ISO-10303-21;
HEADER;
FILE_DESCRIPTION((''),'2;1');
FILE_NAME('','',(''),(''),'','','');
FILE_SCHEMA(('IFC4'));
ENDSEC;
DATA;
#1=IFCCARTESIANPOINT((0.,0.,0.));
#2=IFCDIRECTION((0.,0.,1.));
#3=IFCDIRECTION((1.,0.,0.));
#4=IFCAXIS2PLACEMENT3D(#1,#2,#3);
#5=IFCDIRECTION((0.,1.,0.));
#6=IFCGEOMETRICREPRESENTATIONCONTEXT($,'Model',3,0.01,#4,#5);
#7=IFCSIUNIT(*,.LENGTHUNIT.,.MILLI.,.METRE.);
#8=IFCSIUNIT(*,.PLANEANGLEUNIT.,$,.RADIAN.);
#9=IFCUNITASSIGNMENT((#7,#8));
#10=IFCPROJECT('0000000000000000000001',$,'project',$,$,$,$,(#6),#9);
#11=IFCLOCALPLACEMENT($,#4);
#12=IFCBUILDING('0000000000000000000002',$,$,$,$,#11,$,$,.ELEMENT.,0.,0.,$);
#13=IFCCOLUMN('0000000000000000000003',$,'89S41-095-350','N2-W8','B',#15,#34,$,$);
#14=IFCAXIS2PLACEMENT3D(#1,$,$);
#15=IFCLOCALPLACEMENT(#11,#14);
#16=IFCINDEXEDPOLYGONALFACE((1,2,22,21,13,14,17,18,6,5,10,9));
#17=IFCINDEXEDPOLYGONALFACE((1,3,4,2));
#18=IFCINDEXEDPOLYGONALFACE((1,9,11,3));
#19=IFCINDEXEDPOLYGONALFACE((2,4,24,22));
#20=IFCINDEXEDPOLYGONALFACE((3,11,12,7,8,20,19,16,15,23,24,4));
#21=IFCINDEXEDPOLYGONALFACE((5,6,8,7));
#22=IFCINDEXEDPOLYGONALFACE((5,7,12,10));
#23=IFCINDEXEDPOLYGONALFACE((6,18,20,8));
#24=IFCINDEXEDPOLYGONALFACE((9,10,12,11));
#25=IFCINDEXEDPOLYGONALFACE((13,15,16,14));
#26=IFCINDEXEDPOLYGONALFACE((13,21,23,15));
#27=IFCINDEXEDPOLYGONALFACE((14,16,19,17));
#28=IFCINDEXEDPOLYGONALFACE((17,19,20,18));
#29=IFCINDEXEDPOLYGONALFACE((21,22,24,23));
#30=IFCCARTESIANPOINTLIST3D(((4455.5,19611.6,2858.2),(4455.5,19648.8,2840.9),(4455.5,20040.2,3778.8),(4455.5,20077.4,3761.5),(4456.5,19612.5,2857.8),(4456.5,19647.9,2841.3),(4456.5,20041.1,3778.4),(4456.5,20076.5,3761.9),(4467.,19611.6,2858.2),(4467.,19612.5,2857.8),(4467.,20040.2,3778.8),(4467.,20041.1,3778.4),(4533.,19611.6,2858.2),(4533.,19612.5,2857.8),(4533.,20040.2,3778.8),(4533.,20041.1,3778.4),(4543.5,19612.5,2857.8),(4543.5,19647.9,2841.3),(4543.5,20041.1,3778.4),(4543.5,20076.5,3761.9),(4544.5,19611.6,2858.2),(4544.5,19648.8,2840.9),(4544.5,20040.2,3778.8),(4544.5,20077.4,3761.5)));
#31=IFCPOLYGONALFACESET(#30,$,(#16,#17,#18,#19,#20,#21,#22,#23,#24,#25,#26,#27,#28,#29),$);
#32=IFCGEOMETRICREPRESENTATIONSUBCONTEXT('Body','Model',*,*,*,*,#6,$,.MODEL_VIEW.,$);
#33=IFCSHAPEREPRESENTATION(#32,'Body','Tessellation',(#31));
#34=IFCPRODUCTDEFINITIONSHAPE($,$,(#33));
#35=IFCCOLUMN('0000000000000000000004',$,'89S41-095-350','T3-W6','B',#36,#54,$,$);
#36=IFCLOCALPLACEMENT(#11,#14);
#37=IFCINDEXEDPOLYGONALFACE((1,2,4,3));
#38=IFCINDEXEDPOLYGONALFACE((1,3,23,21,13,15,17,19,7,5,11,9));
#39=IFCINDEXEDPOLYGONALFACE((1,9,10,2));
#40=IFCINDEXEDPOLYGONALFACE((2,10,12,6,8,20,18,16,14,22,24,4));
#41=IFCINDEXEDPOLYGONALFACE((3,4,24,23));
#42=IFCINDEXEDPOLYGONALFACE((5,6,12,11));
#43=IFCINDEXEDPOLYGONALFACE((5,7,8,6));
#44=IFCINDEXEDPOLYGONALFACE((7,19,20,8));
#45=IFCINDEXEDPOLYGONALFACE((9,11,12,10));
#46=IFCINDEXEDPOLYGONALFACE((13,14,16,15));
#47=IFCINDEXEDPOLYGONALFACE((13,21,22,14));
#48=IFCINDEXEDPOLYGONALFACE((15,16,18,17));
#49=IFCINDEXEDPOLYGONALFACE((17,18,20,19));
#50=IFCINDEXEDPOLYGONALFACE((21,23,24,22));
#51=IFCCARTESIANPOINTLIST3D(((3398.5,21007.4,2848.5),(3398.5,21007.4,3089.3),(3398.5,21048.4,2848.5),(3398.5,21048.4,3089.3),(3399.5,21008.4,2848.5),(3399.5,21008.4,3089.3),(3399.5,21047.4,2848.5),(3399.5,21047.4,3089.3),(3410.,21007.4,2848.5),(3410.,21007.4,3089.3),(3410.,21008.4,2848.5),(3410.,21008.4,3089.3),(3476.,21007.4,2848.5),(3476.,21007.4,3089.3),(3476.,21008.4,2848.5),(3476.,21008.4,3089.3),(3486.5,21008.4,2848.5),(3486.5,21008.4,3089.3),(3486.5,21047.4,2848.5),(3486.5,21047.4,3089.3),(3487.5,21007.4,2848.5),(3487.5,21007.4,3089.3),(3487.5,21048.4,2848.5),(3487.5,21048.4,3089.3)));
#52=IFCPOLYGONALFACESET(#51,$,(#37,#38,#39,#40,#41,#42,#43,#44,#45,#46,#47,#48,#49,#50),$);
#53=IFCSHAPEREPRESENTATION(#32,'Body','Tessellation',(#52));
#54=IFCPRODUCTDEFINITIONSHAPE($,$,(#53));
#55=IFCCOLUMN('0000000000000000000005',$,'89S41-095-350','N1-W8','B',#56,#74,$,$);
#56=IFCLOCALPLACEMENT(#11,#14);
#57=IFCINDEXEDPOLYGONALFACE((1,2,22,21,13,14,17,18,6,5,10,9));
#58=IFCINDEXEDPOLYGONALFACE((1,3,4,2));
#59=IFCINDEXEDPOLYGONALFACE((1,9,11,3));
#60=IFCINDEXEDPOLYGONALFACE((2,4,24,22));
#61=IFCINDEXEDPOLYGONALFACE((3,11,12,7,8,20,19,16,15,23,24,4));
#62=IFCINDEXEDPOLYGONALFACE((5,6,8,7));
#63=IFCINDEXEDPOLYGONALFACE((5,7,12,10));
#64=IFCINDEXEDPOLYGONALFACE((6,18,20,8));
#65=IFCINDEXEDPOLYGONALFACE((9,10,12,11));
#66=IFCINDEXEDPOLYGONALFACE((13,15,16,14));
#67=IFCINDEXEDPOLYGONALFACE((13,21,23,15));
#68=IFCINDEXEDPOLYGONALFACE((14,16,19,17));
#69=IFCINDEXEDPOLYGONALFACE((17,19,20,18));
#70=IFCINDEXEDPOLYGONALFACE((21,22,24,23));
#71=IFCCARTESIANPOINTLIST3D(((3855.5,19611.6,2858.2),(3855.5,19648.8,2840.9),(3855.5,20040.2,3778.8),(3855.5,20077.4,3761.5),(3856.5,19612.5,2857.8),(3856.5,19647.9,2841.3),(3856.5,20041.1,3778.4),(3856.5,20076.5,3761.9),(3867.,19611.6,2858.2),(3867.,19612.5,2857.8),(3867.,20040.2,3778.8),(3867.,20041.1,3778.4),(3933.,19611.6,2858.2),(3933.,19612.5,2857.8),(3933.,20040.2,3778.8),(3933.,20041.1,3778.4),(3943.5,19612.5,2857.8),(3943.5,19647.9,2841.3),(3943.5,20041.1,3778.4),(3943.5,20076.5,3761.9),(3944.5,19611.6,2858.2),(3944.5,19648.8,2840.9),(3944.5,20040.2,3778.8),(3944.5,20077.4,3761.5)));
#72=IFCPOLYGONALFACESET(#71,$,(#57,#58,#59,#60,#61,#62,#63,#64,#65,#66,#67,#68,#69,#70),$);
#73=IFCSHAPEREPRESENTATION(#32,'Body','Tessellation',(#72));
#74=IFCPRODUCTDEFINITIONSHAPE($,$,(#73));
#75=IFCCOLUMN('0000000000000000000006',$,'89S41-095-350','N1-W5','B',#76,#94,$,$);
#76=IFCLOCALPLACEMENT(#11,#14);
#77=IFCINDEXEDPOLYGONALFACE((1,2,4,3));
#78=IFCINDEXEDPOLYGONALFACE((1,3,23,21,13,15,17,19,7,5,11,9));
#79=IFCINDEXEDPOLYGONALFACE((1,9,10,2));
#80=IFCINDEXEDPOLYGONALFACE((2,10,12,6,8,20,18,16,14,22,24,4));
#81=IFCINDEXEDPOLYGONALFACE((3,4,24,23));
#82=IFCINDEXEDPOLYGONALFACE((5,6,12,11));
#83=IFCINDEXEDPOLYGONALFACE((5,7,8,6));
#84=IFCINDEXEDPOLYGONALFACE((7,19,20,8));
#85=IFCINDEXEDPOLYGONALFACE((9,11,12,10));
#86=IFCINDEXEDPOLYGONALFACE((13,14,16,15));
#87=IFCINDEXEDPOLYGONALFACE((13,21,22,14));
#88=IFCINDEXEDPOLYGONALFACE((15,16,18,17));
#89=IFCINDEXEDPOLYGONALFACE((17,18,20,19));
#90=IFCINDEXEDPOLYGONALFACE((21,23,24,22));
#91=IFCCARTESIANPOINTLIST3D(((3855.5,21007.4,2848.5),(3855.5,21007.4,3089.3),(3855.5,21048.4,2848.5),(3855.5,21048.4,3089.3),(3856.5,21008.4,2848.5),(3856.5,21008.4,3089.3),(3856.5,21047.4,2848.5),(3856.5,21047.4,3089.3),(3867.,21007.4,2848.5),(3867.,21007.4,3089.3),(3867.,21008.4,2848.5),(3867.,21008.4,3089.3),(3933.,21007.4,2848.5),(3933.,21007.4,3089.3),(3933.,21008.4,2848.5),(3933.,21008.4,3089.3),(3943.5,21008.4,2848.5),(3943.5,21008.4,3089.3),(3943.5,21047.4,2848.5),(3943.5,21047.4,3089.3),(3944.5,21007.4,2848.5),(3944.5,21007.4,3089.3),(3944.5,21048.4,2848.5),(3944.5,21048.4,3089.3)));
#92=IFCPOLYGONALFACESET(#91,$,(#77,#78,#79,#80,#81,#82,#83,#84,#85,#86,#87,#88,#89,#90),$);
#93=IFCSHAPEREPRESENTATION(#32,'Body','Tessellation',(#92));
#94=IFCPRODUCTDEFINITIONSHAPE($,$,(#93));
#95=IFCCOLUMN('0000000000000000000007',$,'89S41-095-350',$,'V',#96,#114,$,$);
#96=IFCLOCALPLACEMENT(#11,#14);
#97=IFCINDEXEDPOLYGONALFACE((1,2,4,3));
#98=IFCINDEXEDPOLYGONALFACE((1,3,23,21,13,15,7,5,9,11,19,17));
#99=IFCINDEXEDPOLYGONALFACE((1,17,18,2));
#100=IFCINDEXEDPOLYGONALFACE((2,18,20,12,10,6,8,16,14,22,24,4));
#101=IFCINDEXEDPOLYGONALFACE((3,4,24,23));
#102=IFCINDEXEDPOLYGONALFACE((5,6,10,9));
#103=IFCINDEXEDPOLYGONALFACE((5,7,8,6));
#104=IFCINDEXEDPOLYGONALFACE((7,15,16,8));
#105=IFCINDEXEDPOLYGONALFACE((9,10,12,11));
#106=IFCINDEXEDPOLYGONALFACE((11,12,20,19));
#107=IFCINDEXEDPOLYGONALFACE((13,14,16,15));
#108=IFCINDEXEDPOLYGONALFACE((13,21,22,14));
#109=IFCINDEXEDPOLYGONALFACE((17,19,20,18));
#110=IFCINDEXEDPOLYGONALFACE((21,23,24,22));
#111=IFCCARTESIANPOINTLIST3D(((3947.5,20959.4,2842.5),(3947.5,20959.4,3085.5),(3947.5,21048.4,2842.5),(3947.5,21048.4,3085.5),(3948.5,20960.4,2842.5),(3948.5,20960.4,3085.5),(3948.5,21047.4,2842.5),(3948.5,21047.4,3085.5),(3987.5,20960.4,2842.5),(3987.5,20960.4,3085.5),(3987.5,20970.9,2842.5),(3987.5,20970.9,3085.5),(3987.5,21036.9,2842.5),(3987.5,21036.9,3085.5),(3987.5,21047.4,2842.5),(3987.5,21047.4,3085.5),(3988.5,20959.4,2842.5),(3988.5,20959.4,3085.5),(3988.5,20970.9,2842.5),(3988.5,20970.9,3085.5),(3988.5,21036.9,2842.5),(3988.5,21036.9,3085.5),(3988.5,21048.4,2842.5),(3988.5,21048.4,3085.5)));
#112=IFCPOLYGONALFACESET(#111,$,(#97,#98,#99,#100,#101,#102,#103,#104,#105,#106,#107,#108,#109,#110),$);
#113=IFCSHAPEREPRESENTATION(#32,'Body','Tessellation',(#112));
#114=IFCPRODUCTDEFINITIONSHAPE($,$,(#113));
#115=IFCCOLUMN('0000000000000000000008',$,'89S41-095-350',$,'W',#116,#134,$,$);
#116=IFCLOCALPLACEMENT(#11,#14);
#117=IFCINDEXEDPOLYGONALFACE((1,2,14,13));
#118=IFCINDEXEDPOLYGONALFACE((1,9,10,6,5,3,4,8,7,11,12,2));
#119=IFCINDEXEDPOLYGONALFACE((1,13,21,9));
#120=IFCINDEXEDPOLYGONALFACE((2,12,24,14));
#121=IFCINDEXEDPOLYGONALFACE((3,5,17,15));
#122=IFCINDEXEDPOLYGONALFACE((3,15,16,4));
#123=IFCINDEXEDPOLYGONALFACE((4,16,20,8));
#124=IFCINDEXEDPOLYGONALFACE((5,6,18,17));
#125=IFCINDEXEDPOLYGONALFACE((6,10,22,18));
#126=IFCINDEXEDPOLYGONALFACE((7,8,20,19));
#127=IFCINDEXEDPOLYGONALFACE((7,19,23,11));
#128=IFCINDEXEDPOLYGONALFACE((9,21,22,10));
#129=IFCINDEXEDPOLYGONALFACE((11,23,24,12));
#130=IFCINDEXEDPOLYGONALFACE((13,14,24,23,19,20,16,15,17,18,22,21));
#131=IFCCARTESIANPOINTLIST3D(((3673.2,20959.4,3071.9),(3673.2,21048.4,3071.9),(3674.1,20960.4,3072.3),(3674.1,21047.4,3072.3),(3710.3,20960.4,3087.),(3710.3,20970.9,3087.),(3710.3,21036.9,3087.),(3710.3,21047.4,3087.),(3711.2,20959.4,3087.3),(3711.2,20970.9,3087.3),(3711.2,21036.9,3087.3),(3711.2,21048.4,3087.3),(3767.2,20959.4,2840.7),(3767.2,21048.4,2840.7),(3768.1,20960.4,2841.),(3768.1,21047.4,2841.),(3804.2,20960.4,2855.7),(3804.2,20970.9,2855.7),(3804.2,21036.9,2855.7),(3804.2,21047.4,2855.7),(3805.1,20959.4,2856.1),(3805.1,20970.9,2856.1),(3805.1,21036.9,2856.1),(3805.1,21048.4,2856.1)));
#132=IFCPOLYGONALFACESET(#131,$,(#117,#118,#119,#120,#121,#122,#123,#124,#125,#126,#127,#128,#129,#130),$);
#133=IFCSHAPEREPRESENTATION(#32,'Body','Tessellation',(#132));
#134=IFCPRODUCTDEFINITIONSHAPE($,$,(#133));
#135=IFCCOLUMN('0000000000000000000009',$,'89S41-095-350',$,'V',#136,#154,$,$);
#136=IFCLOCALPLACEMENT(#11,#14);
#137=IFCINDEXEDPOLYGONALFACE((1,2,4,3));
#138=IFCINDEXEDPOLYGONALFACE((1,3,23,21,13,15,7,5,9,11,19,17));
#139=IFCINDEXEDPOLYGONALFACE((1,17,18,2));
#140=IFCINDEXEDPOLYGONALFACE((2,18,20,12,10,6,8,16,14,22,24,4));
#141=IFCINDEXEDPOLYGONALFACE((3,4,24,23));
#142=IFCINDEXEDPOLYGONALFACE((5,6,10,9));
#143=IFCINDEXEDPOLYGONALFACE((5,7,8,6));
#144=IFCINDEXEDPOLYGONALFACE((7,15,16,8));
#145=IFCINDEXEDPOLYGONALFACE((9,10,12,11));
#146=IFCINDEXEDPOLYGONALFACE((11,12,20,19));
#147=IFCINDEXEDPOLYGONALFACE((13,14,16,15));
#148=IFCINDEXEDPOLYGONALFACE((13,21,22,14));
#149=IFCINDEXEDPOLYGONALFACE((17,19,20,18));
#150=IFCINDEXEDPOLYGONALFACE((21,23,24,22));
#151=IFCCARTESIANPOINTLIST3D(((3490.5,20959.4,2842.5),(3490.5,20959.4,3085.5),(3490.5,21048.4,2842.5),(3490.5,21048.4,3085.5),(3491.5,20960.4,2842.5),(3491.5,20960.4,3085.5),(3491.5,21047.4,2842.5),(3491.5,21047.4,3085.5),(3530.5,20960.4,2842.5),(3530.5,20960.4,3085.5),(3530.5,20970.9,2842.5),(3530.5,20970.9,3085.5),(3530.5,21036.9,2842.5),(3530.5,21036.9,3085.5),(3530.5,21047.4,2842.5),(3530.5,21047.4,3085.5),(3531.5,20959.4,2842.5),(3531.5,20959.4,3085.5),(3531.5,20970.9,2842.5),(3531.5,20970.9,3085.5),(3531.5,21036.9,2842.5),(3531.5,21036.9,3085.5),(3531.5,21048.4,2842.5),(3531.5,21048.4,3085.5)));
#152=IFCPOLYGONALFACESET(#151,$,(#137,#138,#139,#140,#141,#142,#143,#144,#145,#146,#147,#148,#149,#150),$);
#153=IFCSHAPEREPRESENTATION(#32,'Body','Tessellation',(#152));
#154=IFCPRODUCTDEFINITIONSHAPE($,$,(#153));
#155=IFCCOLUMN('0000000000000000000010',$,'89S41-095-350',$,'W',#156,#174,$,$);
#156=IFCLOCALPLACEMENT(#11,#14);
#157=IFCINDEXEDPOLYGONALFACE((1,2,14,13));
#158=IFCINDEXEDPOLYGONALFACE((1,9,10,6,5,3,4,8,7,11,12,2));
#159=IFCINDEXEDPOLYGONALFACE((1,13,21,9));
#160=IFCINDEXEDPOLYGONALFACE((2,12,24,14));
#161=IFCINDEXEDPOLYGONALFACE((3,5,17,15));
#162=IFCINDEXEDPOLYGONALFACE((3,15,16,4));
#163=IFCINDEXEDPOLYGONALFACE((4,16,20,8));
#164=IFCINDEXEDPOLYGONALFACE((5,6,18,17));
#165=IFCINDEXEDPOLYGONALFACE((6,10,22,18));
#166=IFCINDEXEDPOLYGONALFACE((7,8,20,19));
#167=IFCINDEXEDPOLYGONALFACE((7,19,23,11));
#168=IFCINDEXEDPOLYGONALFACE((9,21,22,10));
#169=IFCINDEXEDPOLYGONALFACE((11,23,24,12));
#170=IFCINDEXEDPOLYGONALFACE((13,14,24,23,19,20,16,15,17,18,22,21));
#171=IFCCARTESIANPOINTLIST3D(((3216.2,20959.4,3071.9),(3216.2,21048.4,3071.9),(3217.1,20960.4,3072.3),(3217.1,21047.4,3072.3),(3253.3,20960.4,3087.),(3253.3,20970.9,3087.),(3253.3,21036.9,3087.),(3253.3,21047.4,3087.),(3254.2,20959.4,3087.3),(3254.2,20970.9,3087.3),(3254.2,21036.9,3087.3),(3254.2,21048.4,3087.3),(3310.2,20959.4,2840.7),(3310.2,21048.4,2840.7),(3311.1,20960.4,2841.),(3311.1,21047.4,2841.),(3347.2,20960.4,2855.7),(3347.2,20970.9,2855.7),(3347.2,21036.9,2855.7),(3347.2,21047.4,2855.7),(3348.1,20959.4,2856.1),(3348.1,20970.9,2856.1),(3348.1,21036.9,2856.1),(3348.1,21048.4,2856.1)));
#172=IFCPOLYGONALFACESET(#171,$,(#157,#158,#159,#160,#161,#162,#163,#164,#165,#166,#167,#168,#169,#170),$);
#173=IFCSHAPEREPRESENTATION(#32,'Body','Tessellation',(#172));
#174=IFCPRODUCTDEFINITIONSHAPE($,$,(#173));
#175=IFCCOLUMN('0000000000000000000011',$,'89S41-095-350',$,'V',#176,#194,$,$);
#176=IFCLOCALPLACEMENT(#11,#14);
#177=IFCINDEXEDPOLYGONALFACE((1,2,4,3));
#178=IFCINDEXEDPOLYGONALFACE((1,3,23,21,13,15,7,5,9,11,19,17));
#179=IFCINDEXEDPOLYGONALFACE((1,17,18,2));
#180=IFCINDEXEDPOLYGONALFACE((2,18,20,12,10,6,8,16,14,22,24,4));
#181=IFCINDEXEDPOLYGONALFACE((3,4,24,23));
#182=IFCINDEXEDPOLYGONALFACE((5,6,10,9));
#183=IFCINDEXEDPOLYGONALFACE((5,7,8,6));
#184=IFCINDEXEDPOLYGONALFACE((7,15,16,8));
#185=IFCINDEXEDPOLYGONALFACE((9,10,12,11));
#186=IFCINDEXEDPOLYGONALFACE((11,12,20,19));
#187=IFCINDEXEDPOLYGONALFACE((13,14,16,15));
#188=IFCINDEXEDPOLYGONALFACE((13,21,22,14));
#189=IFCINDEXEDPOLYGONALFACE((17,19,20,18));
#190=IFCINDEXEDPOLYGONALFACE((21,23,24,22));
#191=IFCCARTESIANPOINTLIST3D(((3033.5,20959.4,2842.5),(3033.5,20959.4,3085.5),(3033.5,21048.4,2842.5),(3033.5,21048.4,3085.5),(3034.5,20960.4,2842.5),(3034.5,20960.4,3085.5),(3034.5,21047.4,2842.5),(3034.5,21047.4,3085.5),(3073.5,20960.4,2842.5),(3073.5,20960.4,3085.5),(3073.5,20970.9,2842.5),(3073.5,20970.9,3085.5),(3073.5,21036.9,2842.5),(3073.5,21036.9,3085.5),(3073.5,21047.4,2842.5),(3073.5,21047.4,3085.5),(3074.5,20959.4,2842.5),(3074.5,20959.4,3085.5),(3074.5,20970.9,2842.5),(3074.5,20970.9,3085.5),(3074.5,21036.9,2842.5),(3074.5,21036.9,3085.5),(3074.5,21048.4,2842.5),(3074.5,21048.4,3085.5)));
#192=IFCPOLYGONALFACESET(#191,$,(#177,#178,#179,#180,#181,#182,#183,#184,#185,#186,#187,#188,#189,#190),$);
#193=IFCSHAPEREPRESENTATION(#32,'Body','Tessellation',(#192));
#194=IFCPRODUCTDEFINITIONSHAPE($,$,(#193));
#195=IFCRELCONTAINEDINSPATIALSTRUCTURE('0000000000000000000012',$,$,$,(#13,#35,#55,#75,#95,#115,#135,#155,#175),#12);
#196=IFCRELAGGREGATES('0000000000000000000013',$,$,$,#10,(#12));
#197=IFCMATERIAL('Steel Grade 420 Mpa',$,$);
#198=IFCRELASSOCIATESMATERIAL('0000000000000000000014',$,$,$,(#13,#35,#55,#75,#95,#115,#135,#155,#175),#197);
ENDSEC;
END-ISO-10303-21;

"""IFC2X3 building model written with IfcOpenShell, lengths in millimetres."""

from ifc_helpers import new_model, si_unit, direction, frame, origin, origin_with_axes, origin_2d_with_axis, place, context, subcontext, project, spatial, c_section, extrude, source, transform, mapped, material, element, save


model = new_model("IFC2X3")

# Units and contexts
model_context = context("Model", 3, precision=0.01, world=origin_with_axes(), true_north=direction((0.0, 1.0, 0.0)))
body_context = subcontext(model_context, "Body", "Model", "MODEL_VIEW")
ifc_project = project(units=[si_unit("LENGTHUNIT", "METRE", prefix="MILLI"), si_unit("PLANEANGLEUNIT", "RADIAN")], contexts=[model_context])

# Building
building_placement = place(None, origin_with_axes())
building = spatial("IfcBuilding", under=ifc_project, at=building_placement, CompositionType="ELEMENT", ElevationOfRefHeight=0.0, ElevationOfTerrain=0.0)

# Columns
ifc_material = material(Name="Steel Grade 420 Mpa")
shared_shape_1 = source(origin(), body_context, "Body", "SweptSolid", [
    extrude(c_section(Depth=89.0, Width=41.0, WallThickness=1.0, Girth=11.5, at=origin_2d_with_axis()), origin_with_axes(), (0.0, 0.0, 1.0), 1015.5),
])
column_1_placement = place(None, frame((4500.0, 20058.8, 3770.1), z_axis=(0.0, -0.422026, -0.906584), x_axis=(0.0, -0.906584, 0.422026)))
element("IfcColumn", 1, at=column_1_placement, inside=building, material=ifc_material, Name="89S41-095-350", Description="N2-W8", ObjectType="B", context=body_context, shape_type="MappedRepresentation", body=[
    mapped(shared_shape_1, transform((0.0, 0.0, 0.0), scale=1.0)),
])
shared_shape_2 = source(origin(), body_context, "Body", "SweptSolid", [
    extrude(c_section(Depth=89.0, Width=41.0, WallThickness=1.0, Girth=11.5, at=origin_2d_with_axis()), origin_with_axes(), (0.0, 0.0, 1.0), 240.8),
])
column_2_placement = place(None, frame((3443.0, 21027.9, 3089.3), z_axis=(0.0, 0.0, -1.0), x_axis=(0.0, -1.0, 0.0)))
element("IfcColumn", 2, at=column_2_placement, inside=building, material=ifc_material, Name="89S41-095-350", Description="T3-W6", ObjectType="B", context=body_context, shape_type="MappedRepresentation", body=[
    mapped(shared_shape_2, transform((0.0, 0.0, 0.0), scale=1.0)),
])
shared_shape_3 = source(origin(), body_context, "Body", "SweptSolid", [
    extrude(c_section(Depth=89.0, Width=41.0, WallThickness=1.0, Girth=11.5, at=origin_2d_with_axis()), origin_with_axes(), (0.0, 0.0, 1.0), 1015.5),
])
column_3_placement = place(None, frame((3900.0, 20058.8, 3770.1), z_axis=(0.0, -0.422026, -0.906584), x_axis=(0.0, -0.906584, 0.422026)))
element("IfcColumn", 3, at=column_3_placement, inside=building, material=ifc_material, Name="89S41-095-350", Description="N1-W8", ObjectType="B", context=body_context, shape_type="MappedRepresentation", body=[
    mapped(shared_shape_3, transform((0.0, 0.0, 0.0), scale=1.0)),
])
shared_shape_4 = source(origin(), body_context, "Body", "SweptSolid", [
    extrude(c_section(Depth=89.0, Width=41.0, WallThickness=1.0, Girth=11.5, at=origin_2d_with_axis()), origin_with_axes(), (0.0, 0.0, 1.0), 240.8),
])
column_4_placement = place(None, frame((3900.0, 21027.9, 3089.3), z_axis=(0.0, 0.0, -1.0), x_axis=(0.0, -1.0, 0.0)))
element("IfcColumn", 4, at=column_4_placement, inside=building, material=ifc_material, Name="89S41-095-350", Description="N1-W5", ObjectType="B", context=body_context, shape_type="MappedRepresentation", body=[
    mapped(shared_shape_4, transform((0.0, 0.0, 0.0), scale=1.0)),
])
shared_shape_5 = source(origin(), body_context, "Body", "SweptSolid", [
    extrude(c_section(Depth=89.0, Width=41.0, WallThickness=1.0, Girth=11.5, at=origin_2d_with_axis()), origin_with_axes(), (0.0, 0.0, 1.0), 243.0),
])
column_5_placement = place(None, frame((3968.0, 21003.9, 3085.5), z_axis=(0.0, 0.0, -1.0), x_axis=(1.0, 0.0, 0.0)))
element("IfcColumn", 5, at=column_5_placement, inside=building, material=ifc_material, Name="89S41-095-350", ObjectType="V", context=body_context, shape_type="MappedRepresentation", body=[
    mapped(shared_shape_5, transform((0.0, 0.0, 0.0), scale=1.0)),
])
shared_shape_6 = source(origin(), body_context, "Body", "SweptSolid", [
    extrude(c_section(Depth=89.0, Width=41.0, WallThickness=1.0, Girth=11.5, at=origin_2d_with_axis()), origin_with_axes(), (0.0, 0.0, 1.0), 249.6),
])
column_6_placement = place(None, frame((3692.2, 21003.9, 3079.6), z_axis=(0.376416, 0.0, -0.926451), x_axis=(0.926451, 0.0, 0.376416)))
element("IfcColumn", 6, at=column_6_placement, inside=building, material=ifc_material, Name="89S41-095-350", ObjectType="W", context=body_context, shape_type="MappedRepresentation", body=[
    mapped(shared_shape_6, transform((0.0, 0.0, 0.0), scale=1.0)),
])
shared_shape_7 = source(origin(), body_context, "Body", "SweptSolid", [
    extrude(c_section(Depth=89.0, Width=41.0, WallThickness=1.0, Girth=11.5, at=origin_2d_with_axis()), origin_with_axes(), (0.0, 0.0, 1.0), 243.0),
])
column_7_placement = place(None, frame((3511.0, 21003.9, 3085.5), z_axis=(0.0, 0.0, -1.0), x_axis=(1.0, 0.0, 0.0)))
element("IfcColumn", 7, at=column_7_placement, inside=building, material=ifc_material, Name="89S41-095-350", ObjectType="V", context=body_context, shape_type="MappedRepresentation", body=[
    mapped(shared_shape_7, transform((0.0, 0.0, 0.0), scale=1.0)),
])
shared_shape_8 = source(origin(), body_context, "Body", "SweptSolid", [
    extrude(c_section(Depth=89.0, Width=41.0, WallThickness=1.0, Girth=11.5, at=origin_2d_with_axis()), origin_with_axes(), (0.0, 0.0, 1.0), 249.6),
])
column_8_placement = place(None, frame((3235.2, 21003.9, 3079.6), z_axis=(0.376416, 0.0, -0.926451), x_axis=(0.926451, 0.0, 0.376416)))
element("IfcColumn", 8, at=column_8_placement, inside=building, material=ifc_material, Name="89S41-095-350", ObjectType="W", context=body_context, shape_type="MappedRepresentation", body=[
    mapped(shared_shape_8, transform((0.0, 0.0, 0.0), scale=1.0)),
])
shared_shape_9 = source(origin(), body_context, "Body", "SweptSolid", [
    extrude(c_section(Depth=89.0, Width=41.0, WallThickness=1.0, Girth=11.5, at=origin_2d_with_axis()), origin_with_axes(), (0.0, 0.0, 1.0), 243.0),
])
column_9_placement = place(None, frame((3054.0, 21003.9, 3085.5), z_axis=(0.0, 0.0, -1.0), x_axis=(1.0, 0.0, 0.0)))
element("IfcColumn", 9, at=column_9_placement, inside=building, material=ifc_material, Name="89S41-095-350", ObjectType="V", context=body_context, shape_type="MappedRepresentation", body=[
    mapped(shared_shape_9, transform((0.0, 0.0, 0.0), scale=1.0)),
])

save(model, "model.ifc")
